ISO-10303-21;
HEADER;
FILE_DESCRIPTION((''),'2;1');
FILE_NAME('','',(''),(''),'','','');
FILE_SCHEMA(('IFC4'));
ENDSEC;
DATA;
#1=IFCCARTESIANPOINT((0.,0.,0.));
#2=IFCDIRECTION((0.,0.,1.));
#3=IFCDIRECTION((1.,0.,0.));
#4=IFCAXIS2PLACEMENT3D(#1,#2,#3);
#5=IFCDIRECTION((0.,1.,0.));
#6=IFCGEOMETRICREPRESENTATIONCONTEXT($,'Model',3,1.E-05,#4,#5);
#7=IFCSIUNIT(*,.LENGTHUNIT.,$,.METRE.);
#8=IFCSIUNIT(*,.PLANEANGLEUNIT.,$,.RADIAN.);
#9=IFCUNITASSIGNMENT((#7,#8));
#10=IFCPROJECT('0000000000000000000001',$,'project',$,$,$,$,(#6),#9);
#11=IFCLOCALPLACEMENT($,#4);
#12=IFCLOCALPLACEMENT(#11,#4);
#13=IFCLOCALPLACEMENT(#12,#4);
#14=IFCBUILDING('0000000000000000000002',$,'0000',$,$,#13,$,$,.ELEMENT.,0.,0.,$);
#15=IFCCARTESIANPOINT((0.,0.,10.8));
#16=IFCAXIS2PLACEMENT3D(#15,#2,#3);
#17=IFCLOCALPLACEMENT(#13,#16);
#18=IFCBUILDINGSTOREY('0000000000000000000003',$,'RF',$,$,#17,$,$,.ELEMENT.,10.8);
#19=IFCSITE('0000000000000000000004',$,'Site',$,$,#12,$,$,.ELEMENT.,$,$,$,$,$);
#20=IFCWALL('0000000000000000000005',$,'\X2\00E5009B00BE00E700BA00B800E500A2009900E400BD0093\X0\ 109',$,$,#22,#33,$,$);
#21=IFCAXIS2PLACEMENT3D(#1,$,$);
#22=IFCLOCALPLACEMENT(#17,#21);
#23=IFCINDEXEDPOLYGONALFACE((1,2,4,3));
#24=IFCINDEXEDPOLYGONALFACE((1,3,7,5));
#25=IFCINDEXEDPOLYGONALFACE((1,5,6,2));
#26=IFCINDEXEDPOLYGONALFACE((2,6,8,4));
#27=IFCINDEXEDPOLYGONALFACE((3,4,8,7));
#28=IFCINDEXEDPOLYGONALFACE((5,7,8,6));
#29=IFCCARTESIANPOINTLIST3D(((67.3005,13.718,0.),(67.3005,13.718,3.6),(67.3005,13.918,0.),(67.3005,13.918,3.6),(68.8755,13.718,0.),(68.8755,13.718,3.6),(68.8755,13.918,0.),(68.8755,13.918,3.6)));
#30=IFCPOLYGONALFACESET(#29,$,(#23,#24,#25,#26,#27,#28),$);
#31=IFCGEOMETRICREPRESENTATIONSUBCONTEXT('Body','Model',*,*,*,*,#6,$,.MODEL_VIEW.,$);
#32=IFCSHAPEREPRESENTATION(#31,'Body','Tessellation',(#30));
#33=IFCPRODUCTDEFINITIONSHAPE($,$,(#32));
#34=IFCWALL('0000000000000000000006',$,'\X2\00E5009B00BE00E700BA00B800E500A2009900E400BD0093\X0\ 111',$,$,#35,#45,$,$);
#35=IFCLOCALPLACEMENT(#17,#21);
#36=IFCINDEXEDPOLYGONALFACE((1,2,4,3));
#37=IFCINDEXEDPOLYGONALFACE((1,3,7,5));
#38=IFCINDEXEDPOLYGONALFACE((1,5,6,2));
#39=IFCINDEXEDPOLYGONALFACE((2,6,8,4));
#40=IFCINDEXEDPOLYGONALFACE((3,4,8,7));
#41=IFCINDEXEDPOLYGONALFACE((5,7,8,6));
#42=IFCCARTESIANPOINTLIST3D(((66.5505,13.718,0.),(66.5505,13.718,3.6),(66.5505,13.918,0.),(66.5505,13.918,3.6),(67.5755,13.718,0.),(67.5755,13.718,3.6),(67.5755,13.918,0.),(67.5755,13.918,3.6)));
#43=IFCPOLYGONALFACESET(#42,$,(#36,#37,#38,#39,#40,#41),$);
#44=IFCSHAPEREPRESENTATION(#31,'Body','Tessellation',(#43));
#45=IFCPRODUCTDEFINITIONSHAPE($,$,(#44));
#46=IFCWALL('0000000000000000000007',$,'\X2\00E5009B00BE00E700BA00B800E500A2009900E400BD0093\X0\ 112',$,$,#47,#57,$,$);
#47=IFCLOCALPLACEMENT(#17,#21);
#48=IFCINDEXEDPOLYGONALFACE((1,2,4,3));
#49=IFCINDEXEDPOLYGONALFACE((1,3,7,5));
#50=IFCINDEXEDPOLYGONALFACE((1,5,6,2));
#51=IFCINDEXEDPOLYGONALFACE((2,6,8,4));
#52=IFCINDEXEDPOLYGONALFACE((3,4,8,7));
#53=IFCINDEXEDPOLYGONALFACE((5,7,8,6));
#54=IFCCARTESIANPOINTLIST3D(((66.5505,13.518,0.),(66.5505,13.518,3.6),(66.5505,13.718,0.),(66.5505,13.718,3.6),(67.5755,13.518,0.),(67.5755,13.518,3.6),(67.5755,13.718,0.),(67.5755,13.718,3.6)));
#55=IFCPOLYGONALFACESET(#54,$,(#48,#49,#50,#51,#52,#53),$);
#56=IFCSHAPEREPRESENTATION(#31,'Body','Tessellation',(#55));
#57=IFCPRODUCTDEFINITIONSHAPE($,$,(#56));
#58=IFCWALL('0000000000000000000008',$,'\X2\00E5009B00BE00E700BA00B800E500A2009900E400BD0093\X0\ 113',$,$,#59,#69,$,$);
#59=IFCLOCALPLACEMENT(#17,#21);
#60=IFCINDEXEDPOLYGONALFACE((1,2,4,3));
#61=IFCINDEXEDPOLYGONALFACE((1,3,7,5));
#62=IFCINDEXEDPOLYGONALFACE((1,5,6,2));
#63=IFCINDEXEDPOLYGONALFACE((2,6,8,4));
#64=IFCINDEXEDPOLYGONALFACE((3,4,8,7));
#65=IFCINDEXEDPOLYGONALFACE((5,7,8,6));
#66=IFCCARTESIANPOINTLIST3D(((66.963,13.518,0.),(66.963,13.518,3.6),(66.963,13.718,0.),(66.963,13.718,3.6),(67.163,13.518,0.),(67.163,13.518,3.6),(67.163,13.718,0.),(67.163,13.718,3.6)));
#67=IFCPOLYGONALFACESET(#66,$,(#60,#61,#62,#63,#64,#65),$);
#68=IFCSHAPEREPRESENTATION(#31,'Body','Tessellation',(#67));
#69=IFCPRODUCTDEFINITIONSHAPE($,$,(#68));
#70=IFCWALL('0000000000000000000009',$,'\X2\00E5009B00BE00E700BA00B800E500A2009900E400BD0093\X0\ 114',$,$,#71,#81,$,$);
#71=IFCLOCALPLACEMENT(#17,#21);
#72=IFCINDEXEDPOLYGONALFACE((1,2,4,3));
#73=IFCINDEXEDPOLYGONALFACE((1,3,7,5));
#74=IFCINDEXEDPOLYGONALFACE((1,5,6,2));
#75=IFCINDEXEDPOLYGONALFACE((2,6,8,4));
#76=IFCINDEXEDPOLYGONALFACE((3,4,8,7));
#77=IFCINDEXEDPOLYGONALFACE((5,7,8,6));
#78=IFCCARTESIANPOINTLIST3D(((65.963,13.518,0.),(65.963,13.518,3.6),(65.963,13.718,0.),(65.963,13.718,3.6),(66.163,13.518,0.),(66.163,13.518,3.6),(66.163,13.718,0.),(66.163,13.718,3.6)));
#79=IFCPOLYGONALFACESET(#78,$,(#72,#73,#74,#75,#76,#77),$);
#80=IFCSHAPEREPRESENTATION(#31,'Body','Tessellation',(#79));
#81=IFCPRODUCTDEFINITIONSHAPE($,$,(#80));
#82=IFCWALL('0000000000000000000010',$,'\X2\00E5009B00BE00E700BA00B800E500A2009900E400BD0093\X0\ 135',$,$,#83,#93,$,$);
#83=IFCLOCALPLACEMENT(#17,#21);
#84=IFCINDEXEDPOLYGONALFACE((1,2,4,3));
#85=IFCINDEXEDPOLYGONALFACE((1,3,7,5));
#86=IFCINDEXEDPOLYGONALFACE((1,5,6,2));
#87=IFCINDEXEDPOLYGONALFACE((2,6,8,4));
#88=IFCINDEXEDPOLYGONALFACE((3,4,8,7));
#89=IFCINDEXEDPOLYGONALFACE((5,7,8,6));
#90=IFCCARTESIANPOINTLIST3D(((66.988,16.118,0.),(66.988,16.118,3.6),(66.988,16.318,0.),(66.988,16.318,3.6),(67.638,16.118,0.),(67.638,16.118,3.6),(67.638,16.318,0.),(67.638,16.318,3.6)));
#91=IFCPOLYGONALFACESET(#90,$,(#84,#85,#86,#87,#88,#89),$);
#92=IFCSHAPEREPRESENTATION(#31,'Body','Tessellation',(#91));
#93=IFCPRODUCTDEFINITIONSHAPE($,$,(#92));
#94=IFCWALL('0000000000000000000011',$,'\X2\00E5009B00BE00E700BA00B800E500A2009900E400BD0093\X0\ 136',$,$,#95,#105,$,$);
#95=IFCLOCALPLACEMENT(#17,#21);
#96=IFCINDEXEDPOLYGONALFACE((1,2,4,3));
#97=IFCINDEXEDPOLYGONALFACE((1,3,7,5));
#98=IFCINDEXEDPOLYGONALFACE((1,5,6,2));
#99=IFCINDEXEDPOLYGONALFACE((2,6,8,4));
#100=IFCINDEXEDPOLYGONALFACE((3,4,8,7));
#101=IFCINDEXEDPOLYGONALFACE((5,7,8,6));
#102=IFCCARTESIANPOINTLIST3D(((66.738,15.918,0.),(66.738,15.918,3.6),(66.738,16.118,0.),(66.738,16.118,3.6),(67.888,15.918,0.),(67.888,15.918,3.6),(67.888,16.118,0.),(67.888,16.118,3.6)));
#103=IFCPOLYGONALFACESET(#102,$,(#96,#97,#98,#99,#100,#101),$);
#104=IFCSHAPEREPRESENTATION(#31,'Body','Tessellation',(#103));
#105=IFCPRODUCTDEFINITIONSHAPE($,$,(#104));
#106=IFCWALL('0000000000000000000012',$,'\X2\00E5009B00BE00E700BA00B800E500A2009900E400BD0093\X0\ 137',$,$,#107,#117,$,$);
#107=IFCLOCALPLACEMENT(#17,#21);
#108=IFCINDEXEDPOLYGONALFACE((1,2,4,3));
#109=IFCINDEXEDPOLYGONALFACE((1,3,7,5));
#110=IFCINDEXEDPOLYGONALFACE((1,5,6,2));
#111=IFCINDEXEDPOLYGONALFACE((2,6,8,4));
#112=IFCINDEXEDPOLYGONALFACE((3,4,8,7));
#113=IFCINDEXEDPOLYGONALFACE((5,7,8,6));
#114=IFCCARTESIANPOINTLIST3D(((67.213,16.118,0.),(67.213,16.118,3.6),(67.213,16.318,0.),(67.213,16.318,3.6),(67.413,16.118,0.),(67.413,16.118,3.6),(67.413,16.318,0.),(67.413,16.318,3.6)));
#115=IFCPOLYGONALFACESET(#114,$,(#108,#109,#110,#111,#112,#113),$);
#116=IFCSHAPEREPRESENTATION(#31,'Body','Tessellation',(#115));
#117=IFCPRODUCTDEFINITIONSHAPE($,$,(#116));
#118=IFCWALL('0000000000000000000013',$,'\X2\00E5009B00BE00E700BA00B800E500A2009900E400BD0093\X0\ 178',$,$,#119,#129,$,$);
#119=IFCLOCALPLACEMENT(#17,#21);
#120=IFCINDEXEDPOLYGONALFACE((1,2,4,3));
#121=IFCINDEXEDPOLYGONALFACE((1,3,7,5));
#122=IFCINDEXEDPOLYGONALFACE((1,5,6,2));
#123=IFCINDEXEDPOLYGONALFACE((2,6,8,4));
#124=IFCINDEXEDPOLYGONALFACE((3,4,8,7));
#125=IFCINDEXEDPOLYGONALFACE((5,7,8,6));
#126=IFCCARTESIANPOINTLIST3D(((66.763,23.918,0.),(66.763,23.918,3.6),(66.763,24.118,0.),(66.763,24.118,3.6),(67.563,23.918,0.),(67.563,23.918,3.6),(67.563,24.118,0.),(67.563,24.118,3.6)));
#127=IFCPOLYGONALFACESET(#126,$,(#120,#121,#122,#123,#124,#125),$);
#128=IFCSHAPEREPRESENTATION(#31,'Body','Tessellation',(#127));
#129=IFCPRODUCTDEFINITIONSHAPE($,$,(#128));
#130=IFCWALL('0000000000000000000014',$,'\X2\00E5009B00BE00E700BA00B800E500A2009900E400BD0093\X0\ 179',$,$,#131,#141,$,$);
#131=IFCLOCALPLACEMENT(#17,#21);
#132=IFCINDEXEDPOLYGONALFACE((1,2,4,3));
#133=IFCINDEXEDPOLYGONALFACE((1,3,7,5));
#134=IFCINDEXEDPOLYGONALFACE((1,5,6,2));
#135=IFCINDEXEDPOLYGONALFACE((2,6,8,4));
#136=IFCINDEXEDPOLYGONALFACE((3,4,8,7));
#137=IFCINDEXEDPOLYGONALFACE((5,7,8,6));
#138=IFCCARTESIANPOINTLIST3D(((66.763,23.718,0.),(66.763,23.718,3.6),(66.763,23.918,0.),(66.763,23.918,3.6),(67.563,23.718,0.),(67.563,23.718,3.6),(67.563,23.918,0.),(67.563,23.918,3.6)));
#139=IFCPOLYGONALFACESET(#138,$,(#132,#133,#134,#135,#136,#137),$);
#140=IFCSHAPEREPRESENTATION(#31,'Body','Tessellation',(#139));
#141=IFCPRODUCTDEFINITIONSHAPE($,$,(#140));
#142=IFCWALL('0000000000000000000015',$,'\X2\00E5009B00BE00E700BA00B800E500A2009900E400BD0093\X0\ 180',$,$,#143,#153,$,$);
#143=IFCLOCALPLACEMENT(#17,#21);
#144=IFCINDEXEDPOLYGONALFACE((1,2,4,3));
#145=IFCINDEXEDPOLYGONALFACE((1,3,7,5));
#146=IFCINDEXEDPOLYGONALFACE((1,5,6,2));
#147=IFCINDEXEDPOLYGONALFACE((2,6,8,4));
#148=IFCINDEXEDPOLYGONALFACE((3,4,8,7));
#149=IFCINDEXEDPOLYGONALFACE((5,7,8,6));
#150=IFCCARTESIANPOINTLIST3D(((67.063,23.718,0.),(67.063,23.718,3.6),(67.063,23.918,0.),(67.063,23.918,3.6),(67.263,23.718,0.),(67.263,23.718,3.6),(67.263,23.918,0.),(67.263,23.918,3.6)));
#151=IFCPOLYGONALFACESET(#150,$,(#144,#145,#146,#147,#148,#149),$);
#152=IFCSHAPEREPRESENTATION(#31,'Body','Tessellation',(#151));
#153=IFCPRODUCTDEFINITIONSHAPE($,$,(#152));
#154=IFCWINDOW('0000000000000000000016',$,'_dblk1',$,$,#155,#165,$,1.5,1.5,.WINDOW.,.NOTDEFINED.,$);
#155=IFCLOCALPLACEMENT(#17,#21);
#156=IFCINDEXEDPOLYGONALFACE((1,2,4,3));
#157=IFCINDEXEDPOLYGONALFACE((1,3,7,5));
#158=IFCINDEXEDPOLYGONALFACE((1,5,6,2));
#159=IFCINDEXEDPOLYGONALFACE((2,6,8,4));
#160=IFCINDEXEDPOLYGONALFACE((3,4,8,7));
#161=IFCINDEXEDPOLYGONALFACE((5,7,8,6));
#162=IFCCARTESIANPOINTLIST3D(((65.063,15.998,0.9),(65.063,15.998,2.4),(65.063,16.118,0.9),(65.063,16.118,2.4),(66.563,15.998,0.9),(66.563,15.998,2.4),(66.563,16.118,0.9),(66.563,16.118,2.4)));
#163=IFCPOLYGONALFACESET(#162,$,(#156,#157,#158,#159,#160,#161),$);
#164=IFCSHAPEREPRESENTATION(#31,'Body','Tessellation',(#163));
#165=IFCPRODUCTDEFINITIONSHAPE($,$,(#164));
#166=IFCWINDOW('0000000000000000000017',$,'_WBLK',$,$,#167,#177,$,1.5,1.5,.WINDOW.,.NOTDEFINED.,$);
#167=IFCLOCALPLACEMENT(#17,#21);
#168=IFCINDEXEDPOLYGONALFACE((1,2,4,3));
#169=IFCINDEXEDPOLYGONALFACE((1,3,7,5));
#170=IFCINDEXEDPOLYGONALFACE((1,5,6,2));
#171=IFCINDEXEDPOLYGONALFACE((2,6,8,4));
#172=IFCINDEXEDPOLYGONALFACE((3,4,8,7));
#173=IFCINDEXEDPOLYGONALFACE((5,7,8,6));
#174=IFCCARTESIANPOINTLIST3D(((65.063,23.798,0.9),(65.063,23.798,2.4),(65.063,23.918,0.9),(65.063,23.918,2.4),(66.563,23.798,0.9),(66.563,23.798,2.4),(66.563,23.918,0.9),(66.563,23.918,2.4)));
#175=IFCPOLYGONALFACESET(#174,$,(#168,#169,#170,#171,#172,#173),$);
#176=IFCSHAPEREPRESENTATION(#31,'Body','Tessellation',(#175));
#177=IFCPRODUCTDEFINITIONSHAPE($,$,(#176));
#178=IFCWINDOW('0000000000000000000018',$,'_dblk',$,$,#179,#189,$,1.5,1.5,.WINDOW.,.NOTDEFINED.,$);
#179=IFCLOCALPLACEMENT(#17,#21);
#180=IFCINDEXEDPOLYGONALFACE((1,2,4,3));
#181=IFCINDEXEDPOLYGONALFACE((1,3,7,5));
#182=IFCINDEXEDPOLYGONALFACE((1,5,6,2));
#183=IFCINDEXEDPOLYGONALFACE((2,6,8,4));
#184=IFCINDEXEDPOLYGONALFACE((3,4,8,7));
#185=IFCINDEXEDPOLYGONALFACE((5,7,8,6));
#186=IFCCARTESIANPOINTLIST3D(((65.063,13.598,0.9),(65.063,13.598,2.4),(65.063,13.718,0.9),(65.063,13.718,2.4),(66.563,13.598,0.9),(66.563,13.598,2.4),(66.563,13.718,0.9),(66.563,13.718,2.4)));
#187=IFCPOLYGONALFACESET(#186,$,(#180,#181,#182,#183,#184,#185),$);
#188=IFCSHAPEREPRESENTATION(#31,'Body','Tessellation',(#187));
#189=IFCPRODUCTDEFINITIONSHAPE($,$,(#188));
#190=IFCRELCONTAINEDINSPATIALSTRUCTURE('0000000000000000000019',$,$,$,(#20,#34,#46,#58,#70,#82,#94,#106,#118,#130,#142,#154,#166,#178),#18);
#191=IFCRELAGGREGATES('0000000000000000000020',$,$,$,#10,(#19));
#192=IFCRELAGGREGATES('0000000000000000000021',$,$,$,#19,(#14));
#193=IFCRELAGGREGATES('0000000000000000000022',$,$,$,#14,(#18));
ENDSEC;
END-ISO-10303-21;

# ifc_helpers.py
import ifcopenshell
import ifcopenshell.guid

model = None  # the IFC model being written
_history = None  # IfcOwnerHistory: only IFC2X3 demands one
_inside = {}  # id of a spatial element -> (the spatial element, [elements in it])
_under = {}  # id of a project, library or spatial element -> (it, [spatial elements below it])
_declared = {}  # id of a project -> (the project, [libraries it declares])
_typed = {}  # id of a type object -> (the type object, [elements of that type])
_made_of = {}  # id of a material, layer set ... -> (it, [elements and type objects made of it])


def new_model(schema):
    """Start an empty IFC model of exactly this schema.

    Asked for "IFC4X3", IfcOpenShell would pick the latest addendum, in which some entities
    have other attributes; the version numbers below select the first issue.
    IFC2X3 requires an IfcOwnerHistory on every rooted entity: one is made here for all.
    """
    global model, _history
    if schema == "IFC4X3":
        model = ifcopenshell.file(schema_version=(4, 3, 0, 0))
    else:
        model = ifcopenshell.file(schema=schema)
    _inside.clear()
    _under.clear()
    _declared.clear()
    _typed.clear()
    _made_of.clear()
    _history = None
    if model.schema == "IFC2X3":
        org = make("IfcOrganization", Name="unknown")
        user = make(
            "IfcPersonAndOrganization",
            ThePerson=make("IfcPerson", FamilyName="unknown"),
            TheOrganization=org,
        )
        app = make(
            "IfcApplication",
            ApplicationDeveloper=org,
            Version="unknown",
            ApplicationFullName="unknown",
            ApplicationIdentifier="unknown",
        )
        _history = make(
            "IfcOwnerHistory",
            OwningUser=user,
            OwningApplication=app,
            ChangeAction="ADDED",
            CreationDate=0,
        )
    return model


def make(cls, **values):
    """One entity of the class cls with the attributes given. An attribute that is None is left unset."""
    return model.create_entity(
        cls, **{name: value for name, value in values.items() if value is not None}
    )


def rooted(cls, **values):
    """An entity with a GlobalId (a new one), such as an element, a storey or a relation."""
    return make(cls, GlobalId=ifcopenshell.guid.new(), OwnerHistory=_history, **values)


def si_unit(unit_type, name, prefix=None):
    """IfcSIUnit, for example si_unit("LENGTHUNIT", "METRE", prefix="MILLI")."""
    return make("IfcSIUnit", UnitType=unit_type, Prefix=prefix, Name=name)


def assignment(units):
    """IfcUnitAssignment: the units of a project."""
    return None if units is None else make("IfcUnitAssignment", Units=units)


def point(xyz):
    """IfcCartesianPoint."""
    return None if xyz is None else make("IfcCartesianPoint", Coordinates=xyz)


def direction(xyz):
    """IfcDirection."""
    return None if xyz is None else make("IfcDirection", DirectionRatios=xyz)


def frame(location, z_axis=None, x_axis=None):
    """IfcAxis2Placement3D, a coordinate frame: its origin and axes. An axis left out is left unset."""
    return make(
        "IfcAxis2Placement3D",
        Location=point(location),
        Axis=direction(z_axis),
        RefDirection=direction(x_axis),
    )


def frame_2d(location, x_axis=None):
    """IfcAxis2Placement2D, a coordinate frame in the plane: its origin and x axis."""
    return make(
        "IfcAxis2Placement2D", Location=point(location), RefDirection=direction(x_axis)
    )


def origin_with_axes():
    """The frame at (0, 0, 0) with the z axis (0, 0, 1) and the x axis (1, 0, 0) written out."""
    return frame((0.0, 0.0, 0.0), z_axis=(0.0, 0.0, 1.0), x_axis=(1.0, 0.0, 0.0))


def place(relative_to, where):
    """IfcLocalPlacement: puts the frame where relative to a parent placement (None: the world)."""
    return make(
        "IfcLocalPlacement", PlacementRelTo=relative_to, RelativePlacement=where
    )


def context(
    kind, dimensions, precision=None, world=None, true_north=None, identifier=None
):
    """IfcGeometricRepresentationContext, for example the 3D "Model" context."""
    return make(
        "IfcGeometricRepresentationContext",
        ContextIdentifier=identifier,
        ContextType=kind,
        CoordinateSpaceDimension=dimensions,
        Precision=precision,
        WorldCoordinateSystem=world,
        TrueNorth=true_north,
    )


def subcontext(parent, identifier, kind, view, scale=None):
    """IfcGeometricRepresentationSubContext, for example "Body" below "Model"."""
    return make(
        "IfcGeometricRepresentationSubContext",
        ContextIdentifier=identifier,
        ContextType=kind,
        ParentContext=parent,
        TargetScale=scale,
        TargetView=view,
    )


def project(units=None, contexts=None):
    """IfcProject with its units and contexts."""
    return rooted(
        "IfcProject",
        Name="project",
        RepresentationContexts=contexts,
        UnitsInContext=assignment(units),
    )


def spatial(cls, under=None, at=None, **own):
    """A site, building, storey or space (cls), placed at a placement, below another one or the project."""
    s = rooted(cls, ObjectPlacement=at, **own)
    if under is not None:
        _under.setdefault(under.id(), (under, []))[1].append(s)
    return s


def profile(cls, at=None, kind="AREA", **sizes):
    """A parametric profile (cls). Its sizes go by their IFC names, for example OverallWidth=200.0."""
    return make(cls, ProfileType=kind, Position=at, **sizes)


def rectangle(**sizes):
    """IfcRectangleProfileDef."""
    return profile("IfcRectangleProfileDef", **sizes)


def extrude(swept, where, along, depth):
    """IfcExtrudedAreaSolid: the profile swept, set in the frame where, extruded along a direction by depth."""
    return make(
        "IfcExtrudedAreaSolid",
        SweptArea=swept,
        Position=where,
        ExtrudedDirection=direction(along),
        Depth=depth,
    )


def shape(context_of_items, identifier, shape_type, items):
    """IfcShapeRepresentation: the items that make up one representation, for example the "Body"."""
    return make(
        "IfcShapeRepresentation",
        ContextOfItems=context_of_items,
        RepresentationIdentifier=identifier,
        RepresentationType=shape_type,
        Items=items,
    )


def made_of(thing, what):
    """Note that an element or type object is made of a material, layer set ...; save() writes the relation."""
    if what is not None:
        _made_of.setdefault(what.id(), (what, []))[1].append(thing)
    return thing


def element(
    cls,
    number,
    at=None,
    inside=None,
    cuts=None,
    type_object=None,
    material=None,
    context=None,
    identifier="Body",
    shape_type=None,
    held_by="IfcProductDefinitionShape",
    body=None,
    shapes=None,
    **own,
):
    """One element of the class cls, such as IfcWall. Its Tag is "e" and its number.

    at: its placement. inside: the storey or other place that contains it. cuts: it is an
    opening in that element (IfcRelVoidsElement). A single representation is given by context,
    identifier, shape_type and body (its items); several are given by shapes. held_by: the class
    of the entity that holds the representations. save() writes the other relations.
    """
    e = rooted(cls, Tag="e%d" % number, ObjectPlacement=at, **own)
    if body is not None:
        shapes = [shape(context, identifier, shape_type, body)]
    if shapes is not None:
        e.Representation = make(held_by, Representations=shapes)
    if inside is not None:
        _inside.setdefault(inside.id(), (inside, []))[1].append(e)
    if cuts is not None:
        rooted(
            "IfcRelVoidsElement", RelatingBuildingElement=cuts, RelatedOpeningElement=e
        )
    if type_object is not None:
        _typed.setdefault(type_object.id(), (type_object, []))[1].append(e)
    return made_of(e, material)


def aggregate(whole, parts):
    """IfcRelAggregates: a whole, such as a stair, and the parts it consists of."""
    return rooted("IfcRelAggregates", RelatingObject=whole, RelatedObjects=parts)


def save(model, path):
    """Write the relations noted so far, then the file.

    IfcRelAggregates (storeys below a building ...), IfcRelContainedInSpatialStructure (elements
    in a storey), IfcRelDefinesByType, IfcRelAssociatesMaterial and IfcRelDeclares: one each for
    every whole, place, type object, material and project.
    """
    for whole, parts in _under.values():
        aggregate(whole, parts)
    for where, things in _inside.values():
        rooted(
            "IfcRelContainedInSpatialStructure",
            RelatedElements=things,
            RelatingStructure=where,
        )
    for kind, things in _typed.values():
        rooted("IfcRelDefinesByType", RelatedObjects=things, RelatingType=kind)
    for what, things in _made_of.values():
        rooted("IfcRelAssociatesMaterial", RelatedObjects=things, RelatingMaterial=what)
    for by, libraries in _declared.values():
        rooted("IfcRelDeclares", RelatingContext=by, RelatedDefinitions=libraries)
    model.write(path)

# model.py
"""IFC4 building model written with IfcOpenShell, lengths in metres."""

from ifc_helpers import new_model, si_unit, direction, frame, frame_2d, origin_with_axes, place, context, subcontext, project, spatial, rectangle, extrude, element, save


model = new_model("IFC4")

# Units and contexts
model_context = context("Model", 3, precision=1e-05, world=origin_with_axes(), true_north=direction((0.0, 1.0, 0.0)))
body_context = subcontext(model_context, "Body", "Model", "MODEL_VIEW")
ifc_project = project(units=[si_unit("LENGTHUNIT", "METRE"), si_unit("PLANEANGLEUNIT", "RADIAN")], contexts=[model_context])

# Site, building, storey
placement = place(None, origin_with_axes())
site_placement = place(placement, origin_with_axes())
site = spatial("IfcSite", under=ifc_project, at=site_placement, Name="Site", CompositionType="ELEMENT")
building_placement = place(site_placement, origin_with_axes())
building = spatial("IfcBuilding", under=site, at=building_placement, Name="0000", CompositionType="ELEMENT", ElevationOfRefHeight=0.0, ElevationOfTerrain=0.0)
storey_placement = place(building_placement, frame((0.0, 0.0, 10.8), z_axis=(0.0, 0.0, 1.0), x_axis=(1.0, 0.0, 0.0)))
storey = spatial("IfcBuildingStorey", under=building, at=storey_placement, Name="RF", CompositionType="ELEMENT", Elevation=10.8)

# Walls
wall_1_placement = place(storey_placement, frame((68.088, 13.818, 0.0), z_axis=(0.0, 0.0, 1.0), x_axis=(1.0, 0.0, 0.0)))
element("IfcWall", 1, at=wall_1_placement, inside=storey, Name="å\u009b¾çº¸å¢\u0099ä½\u0093 109", context=body_context, shape_type="SweptSolid", body=[
    extrude(rectangle(XDim=1.575, YDim=0.2, at=frame_2d((0.0, 0.0), x_axis=(1.0, 0.0, 0.0))), frame((0.0, 0.0, 0.0), z_axis=(0.0, 0.0, 1.0)), (0.0, 0.0, 1.0), 3.6),
])
for number, where, z_axis, x_axis, name in (
    (2, (67.063, 13.818, 0.0), (0.0, 0.0, 1.0), (1.0, 0.0, 0.0), "å\u009b¾çº¸å¢\u0099ä½\u0093 111"),
    (3, (67.063, 13.618, 0.0), (0.0, 0.0, 1.0), (1.0, 0.0, 0.0), "å\u009b¾çº¸å¢\u0099ä½\u0093 112"),
):
    element("IfcWall", number, at=place(storey_placement, frame(where, z_axis=z_axis, x_axis=x_axis)), inside=storey, Name=name, context=body_context, shape_type="SweptSolid", body=[
        extrude(rectangle(XDim=1.025, YDim=0.2, at=frame_2d((0.0, 0.0), x_axis=(1.0, 0.0, 0.0))), frame((0.0, 0.0, 0.0), z_axis=(0.0, 0.0, 1.0)), (0.0, 0.0, 1.0), 3.6),
    ])
for number, where, z_axis, x_axis, name in (
    (4, (67.063, 13.618, 0.0), (0.0, 0.0, 1.0), (0.0, 1.0, 0.0), "å\u009b¾çº¸å¢\u0099ä½\u0093 113"),
    (5, (66.063, 13.618, 0.0), (0.0, 0.0, 1.0), (0.0, 1.0, 0.0), "å\u009b¾çº¸å¢\u0099ä½\u0093 114"),
):
    element("IfcWall", number, at=place(storey_placement, frame(where, z_axis=z_axis, x_axis=x_axis)), inside=storey, Name=name, context=body_context, shape_type="SweptSolid", body=[
        extrude(rectangle(XDim=0.2, YDim=0.2, at=frame_2d((0.0, 0.0), x_axis=(1.0, 0.0, 0.0))), frame((0.0, 0.0, 0.0), z_axis=(0.0, 0.0, 1.0)), (0.0, 0.0, 1.0), 3.6),
    ])
wall_2_placement = place(storey_placement, frame((67.313, 16.218, 0.0), z_axis=(0.0, 0.0, 1.0), x_axis=(1.0, 0.0, 0.0)))
element("IfcWall", 6, at=wall_2_placement, inside=storey, Name="å\u009b¾çº¸å¢\u0099ä½\u0093 135", context=body_context, shape_type="SweptSolid", body=[
    extrude(rectangle(XDim=0.65, YDim=0.2, at=frame_2d((0.0, 0.0), x_axis=(1.0, 0.0, 0.0))), frame((0.0, 0.0, 0.0), z_axis=(0.0, 0.0, 1.0)), (0.0, 0.0, 1.0), 3.6),
])
wall_3_placement = place(storey_placement, frame((67.313, 16.018, 0.0), z_axis=(0.0, 0.0, 1.0), x_axis=(1.0, 0.0, 0.0)))
element("IfcWall", 7, at=wall_3_placement, inside=storey, Name="å\u009b¾çº¸å¢\u0099ä½\u0093 136", context=body_context, shape_type="SweptSolid", body=[
    extrude(rectangle(XDim=1.15, YDim=0.2, at=frame_2d((0.0, 0.0), x_axis=(1.0, 0.0, 0.0))), frame((0.0, 0.0, 0.0), z_axis=(0.0, 0.0, 1.0)), (0.0, 0.0, 1.0), 3.6),
])
wall_4_placement = place(storey_placement, frame((67.313, 16.218, 0.0), z_axis=(0.0, 0.0, 1.0), x_axis=(0.0, -1.0, 0.0)))
element("IfcWall", 8, at=wall_4_placement, inside=storey, Name="å\u009b¾çº¸å¢\u0099ä½\u0093 137", context=body_context, shape_type="SweptSolid", body=[
    extrude(rectangle(XDim=0.2, YDim=0.2, at=frame_2d((0.0, 0.0), x_axis=(1.0, 0.0, 0.0))), frame((0.0, 0.0, 0.0), z_axis=(0.0, 0.0, 1.0)), (0.0, 0.0, 1.0), 3.6),
])
for number, where, z_axis, x_axis, name in (
    (9, (67.163, 24.018, 0.0), (0.0, 0.0, 1.0), (1.0, 0.0, 0.0), "å\u009b¾çº¸å¢\u0099ä½\u0093 178"),
    (10, (67.163, 23.818, 0.0), (0.0, 0.0, 1.0), (1.0, 0.0, 0.0), "å\u009b¾çº¸å¢\u0099ä½\u0093 179"),
):
    element("IfcWall", number, at=place(storey_placement, frame(where, z_axis=z_axis, x_axis=x_axis)), inside=storey, Name=name, context=body_context, shape_type="SweptSolid", body=[
        extrude(rectangle(XDim=0.8, YDim=0.2, at=frame_2d((0.0, 0.0), x_axis=(1.0, 0.0, 0.0))), frame((0.0, 0.0, 0.0), z_axis=(0.0, 0.0, 1.0)), (0.0, 0.0, 1.0), 3.6),
    ])
wall_5_placement = place(storey_placement, frame((67.163, 23.818, 0.0), z_axis=(0.0, 0.0, 1.0), x_axis=(0.0, 1.0, 0.0)))
element("IfcWall", 11, at=wall_5_placement, inside=storey, Name="å\u009b¾çº¸å¢\u0099ä½\u0093 180", context=body_context, shape_type="SweptSolid", body=[
    extrude(rectangle(XDim=0.2, YDim=0.2, at=frame_2d((0.0, 0.0), x_axis=(1.0, 0.0, 0.0))), frame((0.0, 0.0, 0.0), z_axis=(0.0, 0.0, 1.0)), (0.0, 0.0, 1.0), 3.6),
])

# Windows
for number, where, z_axis, x_axis, name in (
    (12, (65.813, 16.058, 0.9), (0.0, 0.0, 1.0), (1.0, 0.0, 0.0), "_dblk1"),
    (13, (65.813, 23.858, 0.9), (0.0, 0.0, 1.0), (1.0, 0.0, 0.0), "_WBLK"),
    (14, (65.813, 13.658, 0.9), (0.0, 0.0, 1.0), (1.0, 0.0, 0.0), "_dblk"),
):
    element("IfcWindow", number, at=place(storey_placement, frame(where, z_axis=z_axis, x_axis=x_axis)), inside=storey, Name=name, OverallHeight=1.5, OverallWidth=1.5, PartitioningType="NOTDEFINED", PredefinedType="WINDOW", context=body_context, shape_type="SweptSolid", body=[
        extrude(rectangle(XDim=1.5, YDim=0.12, at=frame_2d((0.0, 0.0), x_axis=(1.0, 0.0, 0.0))), frame((0.0, 0.0, 0.0), z_axis=(0.0, 0.0, 1.0)), (0.0, 0.0, 1.0), 1.5),
    ])

save(model, "model.ifc")
